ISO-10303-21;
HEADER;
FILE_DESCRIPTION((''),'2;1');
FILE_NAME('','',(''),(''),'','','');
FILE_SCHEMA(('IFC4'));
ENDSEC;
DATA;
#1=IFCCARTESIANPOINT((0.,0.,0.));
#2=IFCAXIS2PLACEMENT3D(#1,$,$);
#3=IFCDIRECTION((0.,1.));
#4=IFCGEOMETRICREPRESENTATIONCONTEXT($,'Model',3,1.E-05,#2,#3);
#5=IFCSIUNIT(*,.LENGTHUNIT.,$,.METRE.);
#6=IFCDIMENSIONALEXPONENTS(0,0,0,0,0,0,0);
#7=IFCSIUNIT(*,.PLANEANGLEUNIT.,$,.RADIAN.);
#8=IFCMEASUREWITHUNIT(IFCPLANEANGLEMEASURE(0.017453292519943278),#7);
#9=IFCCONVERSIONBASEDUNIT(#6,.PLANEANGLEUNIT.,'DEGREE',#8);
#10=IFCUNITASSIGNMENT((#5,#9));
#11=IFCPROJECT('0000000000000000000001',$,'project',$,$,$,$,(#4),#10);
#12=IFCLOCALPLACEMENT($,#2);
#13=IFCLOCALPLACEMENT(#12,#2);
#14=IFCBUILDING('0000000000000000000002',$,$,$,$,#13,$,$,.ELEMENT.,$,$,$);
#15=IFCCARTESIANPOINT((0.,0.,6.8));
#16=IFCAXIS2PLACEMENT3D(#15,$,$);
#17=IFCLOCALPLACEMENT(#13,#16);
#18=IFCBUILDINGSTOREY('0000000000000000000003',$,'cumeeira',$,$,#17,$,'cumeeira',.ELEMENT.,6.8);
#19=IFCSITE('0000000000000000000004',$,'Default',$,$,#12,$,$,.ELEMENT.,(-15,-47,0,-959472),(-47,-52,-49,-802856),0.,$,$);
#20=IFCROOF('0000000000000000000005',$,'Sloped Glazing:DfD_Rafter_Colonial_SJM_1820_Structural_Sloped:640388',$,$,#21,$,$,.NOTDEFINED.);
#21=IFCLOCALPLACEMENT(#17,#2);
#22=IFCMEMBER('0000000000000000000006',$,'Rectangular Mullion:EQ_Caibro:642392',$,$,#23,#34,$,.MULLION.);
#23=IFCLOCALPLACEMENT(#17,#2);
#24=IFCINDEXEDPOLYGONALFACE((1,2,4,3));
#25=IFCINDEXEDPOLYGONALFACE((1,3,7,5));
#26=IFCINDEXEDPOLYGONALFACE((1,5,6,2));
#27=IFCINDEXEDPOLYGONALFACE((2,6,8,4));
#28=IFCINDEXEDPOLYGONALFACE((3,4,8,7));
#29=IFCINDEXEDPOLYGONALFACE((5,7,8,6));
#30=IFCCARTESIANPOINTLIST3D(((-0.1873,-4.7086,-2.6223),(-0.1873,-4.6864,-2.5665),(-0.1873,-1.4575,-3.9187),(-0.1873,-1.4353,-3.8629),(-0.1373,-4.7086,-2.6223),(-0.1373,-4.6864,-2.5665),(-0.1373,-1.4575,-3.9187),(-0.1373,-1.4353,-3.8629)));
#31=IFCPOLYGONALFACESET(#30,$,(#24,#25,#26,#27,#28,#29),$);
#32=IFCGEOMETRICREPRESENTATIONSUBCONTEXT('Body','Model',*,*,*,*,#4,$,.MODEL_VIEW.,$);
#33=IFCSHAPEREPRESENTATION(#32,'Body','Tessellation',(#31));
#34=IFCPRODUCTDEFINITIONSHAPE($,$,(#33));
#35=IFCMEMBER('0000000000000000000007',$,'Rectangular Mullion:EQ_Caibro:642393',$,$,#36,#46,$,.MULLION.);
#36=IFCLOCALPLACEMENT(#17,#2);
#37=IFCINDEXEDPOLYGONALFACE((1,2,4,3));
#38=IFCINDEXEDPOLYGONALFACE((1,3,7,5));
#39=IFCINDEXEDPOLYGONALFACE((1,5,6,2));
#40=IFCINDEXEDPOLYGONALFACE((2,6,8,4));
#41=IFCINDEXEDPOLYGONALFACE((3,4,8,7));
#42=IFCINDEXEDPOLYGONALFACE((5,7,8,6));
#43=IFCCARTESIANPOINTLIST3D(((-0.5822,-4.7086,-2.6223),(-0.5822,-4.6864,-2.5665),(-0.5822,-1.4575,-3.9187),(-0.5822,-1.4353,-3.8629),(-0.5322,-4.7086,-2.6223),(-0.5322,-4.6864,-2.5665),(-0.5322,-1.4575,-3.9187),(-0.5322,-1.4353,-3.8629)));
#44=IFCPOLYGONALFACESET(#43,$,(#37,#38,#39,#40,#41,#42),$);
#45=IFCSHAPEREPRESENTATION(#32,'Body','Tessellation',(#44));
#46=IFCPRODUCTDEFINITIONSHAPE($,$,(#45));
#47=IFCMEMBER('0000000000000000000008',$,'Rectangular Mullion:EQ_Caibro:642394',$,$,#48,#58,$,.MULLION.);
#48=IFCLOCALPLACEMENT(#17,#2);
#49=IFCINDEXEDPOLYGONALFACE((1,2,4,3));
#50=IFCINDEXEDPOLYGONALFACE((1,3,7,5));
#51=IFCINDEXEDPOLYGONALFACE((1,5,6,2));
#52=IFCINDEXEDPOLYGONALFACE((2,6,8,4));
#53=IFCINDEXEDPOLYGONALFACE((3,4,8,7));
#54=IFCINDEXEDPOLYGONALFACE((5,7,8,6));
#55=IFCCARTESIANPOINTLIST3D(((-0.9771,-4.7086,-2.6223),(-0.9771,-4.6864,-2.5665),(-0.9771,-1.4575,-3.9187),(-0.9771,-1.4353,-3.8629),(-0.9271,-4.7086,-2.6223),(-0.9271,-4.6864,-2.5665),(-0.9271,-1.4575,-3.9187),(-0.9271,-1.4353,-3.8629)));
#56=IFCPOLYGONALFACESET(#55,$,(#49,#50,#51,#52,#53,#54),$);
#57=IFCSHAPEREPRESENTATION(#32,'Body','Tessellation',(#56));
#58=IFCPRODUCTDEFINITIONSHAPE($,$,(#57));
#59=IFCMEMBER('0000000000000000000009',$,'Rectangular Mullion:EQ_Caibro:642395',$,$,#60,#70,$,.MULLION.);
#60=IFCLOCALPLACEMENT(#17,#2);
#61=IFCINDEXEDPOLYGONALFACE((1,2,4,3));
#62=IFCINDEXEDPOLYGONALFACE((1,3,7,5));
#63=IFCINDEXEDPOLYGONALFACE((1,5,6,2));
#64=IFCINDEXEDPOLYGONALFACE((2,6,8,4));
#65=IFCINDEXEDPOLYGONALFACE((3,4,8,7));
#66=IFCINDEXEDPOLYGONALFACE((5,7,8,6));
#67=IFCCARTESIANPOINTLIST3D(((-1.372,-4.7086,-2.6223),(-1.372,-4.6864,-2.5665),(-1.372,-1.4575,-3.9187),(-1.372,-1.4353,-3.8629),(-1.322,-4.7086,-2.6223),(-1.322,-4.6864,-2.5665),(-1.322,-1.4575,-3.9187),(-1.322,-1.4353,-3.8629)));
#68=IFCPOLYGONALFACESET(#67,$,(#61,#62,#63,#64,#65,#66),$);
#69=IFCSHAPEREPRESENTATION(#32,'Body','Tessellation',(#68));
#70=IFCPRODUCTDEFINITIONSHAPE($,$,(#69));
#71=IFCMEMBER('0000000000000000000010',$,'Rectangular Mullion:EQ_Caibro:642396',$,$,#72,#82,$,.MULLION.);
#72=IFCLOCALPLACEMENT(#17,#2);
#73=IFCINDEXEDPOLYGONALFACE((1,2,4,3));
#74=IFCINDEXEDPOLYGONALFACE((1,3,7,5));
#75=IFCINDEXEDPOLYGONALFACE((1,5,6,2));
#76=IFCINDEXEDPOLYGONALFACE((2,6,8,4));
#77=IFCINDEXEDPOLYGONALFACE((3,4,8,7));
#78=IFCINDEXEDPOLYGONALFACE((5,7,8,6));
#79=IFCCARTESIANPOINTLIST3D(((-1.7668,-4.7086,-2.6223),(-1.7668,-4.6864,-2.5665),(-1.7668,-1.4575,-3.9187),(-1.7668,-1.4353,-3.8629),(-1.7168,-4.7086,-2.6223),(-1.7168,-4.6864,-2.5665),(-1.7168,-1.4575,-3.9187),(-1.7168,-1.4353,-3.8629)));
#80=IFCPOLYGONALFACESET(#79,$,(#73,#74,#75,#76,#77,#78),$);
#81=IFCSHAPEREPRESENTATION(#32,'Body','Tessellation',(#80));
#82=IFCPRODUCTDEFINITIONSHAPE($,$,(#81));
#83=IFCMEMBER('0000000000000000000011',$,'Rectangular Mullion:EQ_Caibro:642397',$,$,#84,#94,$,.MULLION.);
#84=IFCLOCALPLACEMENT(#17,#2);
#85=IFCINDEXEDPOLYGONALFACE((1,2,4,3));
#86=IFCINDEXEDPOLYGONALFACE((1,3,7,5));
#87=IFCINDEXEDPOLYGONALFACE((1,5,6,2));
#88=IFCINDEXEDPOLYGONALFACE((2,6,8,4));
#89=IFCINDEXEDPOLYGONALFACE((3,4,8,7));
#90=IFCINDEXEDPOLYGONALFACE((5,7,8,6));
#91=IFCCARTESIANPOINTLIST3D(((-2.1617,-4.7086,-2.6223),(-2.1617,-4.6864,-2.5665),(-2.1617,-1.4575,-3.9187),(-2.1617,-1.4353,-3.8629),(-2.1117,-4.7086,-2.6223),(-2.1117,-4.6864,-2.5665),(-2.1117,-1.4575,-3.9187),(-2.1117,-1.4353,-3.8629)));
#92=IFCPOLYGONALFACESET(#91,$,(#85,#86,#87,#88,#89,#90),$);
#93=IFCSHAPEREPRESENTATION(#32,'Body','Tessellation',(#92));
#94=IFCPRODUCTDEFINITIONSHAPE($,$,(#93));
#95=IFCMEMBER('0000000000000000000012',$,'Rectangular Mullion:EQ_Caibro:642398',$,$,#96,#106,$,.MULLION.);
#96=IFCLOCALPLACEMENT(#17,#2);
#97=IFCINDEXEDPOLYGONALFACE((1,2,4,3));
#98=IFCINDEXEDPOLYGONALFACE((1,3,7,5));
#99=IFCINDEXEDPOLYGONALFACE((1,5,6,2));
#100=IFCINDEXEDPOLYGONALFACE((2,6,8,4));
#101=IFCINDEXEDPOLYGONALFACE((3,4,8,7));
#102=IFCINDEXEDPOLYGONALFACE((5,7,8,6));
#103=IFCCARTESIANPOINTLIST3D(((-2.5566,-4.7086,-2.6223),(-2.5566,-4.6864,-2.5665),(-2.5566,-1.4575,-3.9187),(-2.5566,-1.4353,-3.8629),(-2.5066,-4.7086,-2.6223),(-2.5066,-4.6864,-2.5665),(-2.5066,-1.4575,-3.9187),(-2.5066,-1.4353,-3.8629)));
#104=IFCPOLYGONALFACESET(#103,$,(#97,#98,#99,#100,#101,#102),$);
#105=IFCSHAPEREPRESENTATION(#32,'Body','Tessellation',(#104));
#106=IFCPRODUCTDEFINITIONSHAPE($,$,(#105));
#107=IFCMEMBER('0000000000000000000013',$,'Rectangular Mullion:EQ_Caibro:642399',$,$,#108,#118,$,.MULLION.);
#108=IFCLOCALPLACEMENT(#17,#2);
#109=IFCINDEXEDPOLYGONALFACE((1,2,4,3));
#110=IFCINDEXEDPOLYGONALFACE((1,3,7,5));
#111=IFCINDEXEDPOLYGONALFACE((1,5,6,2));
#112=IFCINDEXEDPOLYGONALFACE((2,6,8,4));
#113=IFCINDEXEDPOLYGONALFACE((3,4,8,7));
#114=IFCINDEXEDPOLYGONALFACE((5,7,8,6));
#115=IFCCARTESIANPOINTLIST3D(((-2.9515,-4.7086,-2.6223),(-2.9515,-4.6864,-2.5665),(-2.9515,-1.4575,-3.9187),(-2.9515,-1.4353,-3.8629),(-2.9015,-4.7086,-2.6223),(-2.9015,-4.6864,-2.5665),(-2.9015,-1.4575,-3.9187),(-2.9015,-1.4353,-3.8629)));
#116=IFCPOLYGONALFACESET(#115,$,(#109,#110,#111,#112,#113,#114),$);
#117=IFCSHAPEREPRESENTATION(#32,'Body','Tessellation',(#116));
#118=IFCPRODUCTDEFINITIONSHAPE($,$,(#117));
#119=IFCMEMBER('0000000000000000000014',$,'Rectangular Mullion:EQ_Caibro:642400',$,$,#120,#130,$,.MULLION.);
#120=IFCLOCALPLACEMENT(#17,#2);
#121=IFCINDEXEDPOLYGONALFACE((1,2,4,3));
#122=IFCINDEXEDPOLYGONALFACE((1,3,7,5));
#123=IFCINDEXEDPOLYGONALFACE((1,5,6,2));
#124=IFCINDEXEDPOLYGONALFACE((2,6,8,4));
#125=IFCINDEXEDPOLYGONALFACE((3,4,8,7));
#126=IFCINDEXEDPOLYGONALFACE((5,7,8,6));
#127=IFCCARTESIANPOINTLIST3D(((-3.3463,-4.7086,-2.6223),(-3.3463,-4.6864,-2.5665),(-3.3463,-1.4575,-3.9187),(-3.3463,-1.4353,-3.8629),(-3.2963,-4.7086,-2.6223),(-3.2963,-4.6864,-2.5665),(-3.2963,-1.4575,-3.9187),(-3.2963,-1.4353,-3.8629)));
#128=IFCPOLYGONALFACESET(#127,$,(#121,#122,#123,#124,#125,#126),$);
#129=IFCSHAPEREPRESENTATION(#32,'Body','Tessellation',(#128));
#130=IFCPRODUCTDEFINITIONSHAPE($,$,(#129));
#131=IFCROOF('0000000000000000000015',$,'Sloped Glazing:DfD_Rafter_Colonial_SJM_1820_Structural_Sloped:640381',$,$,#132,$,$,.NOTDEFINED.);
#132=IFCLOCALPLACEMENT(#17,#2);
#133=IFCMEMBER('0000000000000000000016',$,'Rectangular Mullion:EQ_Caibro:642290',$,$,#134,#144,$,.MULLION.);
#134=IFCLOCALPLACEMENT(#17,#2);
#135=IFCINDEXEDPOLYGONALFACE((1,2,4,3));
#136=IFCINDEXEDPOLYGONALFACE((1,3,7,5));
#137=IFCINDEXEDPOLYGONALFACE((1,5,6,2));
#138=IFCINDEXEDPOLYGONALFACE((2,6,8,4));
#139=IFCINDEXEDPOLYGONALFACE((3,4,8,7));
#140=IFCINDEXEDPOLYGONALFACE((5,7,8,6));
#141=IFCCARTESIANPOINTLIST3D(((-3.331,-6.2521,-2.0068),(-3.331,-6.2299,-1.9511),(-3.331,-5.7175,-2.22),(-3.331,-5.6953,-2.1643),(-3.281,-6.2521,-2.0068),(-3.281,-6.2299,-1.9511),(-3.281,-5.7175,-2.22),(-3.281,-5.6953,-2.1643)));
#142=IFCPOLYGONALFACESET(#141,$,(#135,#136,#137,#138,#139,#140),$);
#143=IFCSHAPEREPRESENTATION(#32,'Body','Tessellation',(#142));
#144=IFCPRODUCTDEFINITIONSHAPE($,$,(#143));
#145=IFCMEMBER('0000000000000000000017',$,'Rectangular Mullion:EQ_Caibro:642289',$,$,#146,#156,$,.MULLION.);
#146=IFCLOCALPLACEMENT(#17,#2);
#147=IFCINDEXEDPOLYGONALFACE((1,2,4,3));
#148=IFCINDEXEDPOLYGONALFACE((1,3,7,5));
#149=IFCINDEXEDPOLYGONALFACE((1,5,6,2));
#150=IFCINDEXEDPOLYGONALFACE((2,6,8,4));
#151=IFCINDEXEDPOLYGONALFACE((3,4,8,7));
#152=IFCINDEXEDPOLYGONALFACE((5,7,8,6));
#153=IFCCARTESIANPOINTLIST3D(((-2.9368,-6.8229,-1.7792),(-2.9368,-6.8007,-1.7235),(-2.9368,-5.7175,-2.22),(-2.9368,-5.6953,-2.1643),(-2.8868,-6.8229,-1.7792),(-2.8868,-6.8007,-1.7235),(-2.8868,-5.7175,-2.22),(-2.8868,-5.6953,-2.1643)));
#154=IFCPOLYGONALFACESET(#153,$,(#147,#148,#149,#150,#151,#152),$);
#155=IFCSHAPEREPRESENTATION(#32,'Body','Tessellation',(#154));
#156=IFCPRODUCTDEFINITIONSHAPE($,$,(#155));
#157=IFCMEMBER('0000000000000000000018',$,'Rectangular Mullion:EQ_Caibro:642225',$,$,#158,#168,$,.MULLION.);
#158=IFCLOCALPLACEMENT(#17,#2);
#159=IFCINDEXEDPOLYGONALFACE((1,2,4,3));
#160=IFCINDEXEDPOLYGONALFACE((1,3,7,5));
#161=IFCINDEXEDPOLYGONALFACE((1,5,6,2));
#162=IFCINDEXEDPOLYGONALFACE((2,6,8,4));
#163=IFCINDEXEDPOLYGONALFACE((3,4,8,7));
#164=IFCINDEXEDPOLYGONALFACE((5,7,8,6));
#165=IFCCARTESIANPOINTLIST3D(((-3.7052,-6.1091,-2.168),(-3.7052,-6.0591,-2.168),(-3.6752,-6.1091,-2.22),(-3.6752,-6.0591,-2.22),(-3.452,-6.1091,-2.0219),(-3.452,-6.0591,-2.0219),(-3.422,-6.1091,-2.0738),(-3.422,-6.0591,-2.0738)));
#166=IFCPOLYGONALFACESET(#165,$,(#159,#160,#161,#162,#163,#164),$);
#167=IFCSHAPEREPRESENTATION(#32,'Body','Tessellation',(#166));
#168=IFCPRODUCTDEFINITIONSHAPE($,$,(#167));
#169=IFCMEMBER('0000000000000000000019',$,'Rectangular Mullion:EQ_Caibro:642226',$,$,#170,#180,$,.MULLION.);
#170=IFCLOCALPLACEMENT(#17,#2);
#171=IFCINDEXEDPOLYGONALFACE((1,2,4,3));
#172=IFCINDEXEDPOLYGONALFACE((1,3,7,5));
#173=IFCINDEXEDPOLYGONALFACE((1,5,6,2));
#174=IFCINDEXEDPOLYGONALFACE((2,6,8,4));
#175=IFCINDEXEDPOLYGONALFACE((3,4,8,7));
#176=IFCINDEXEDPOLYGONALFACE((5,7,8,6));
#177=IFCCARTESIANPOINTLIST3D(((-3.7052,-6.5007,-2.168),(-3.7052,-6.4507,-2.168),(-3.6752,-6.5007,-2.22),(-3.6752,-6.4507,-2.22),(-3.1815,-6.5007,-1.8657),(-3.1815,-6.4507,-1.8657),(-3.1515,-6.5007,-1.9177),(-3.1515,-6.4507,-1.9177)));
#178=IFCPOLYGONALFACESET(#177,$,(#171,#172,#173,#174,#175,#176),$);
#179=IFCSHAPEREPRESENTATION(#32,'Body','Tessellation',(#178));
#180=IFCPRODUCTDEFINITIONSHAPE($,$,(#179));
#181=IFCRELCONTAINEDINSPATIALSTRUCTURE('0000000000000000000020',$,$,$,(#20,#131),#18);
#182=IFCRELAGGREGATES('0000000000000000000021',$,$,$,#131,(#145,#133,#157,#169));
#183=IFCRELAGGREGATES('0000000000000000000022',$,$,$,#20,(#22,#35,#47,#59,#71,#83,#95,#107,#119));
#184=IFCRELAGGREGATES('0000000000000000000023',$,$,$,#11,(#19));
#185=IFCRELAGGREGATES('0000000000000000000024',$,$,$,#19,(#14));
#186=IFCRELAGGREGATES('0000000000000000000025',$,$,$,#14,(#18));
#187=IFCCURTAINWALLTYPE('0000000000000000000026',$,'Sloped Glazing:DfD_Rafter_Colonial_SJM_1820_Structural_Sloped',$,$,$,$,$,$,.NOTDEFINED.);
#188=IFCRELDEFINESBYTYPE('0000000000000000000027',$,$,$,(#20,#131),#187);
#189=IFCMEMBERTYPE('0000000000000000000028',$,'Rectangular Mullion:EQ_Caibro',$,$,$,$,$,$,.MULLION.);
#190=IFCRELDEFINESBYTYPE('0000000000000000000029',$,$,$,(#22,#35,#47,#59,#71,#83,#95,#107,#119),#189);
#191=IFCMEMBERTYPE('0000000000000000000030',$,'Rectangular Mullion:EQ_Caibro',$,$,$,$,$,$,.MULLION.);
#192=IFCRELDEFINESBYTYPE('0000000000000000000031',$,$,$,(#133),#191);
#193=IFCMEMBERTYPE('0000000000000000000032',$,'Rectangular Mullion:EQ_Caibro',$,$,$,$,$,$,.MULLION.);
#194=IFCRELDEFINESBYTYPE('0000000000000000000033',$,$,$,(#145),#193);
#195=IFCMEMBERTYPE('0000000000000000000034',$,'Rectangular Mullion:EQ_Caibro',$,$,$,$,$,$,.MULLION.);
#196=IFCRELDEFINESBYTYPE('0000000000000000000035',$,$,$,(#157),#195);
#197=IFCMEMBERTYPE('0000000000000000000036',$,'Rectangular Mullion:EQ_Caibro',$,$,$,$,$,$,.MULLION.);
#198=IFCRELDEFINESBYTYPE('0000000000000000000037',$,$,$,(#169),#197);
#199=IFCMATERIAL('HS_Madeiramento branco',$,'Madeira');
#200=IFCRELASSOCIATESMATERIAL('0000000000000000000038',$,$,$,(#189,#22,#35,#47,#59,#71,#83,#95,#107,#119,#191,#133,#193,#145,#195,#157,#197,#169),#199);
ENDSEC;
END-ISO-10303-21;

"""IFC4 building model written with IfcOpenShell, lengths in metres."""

from ifc_helpers import new_model, entity, si_unit, converted_unit, direction, frame, origin, place, context, subcontext, project, spatial, indexed_curve, outline, extrude, source, transform, mapped, material, type_object, type_shapes, element, aggregate, save


model = new_model("IFC4")

# Units and contexts
model_context = context("Model", 3, precision=1e-05, world=origin(), true_north=direction((0.0, 1.0)))
body_context = subcontext(model_context, "Body", "Model", "MODEL_VIEW")
ifc_project = project(units=[si_unit("LENGTHUNIT", "METRE"), converted_unit("PLANEANGLEUNIT", "DEGREE", entity("IfcPlaneAngleMeasure", 0.017453292519943278), si_unit("PLANEANGLEUNIT", "RADIAN"), dimensions=[0, 0, 0, 0, 0, 0, 0])], contexts=[model_context])

# Site, building, storey
site_placement = place(None, origin())
site = spatial("IfcSite", under=ifc_project, at=site_placement, Name="Default", CompositionType="ELEMENT", RefLatitude=(-15, -47, 0, -959472), RefLongitude=(-47, -52, -49, -802856), RefElevation=0.0)
building_placement = place(site_placement, origin())
building = spatial("IfcBuilding", under=site, at=building_placement, CompositionType="ELEMENT")
storey_placement = place(building_placement, frame((0.0, 0.0, 6.8)))
storey = spatial("IfcBuildingStorey", under=building, at=storey_placement, Name="cumeeira", LongName="cumeeira", CompositionType="ELEMENT", Elevation=6.8)

# Roofs, members
curtain_wall_type = type_object("IfcCurtainWallType", Name="Sloped Glazing:DfD_Rafter_Colonial_SJM_1820_Structural_Sloped", PredefinedType="NOTDEFINED")
roof_1_placement = place(storey_placement, frame((0.0, 0.0, -6.8)))
roof_1 = element("IfcRoof", 1, at=roof_1_placement, inside=storey, type_object=curtain_wall_type, Name="Sloped Glazing:DfD_Rafter_Colonial_SJM_1820_Structural_Sloped:640388", PredefinedType="NOTDEFINED")
ifc_material = material(Name="HS_Madeiramento branco", Category="Madeira")
member_type_1 = type_object("IfcMemberType", Name="Rectangular Mullion:EQ_Caibro", PredefinedType="MULLION", material=ifc_material)
shared_shape_1 = source(origin(), body_context, "Body", "SweptSolid", [
    extrude(outline(indexed_curve([(-0.025, -0.03), (0.025, -0.03), (0.025, 0.03), (-0.025, 0.03), (-0.025, -0.03)], self_intersect=False)), frame((0.0, -0.03, -3.5), z_axis=(0.0, 0.0, 1.0), x_axis=(-1.0, 0.0, 0.0)), (0.0, 0.0, 1.0), 3.5),
])
type_shapes(member_type_1, [shared_shape_1])
member_1_placement = place(roof_1_placement, frame((-0.1623, -4.7086, 4.1777), z_axis=(0.0, -0.928874, 0.370395), x_axis=(-1.0, 0.0, 0.0)))
member_1 = element("IfcMember", 2, at=member_1_placement, type_object=member_type_1, material=ifc_material, Name="Rectangular Mullion:EQ_Caibro:642392", PredefinedType="MULLION", context=body_context, shape_type="MappedRepresentation", body=[
    mapped(shared_shape_1, transform((0.0, 0.0, 0.0), scale=1.0)),
])
member_2_placement = place(roof_1_placement, frame((-0.5572, -4.7086, 4.1777), z_axis=(0.0, -0.928874, 0.370395), x_axis=(-1.0, 0.0, 0.0)))
member_2 = element("IfcMember", 3, at=member_2_placement, type_object=member_type_1, material=ifc_material, Name="Rectangular Mullion:EQ_Caibro:642393", PredefinedType="MULLION", context=body_context, shape_type="MappedRepresentation", body=[
    mapped(shared_shape_1, transform((0.0, 0.0, 0.0), scale=1.0)),
])
member_3_placement = place(roof_1_placement, frame((-0.9521, -4.7086, 4.1777), z_axis=(0.0, -0.928874, 0.370395), x_axis=(-1.0, 0.0, 0.0)))
member_3 = element("IfcMember", 4, at=member_3_placement, type_object=member_type_1, material=ifc_material, Name="Rectangular Mullion:EQ_Caibro:642394", PredefinedType="MULLION", context=body_context, shape_type="MappedRepresentation", body=[
    mapped(shared_shape_1, transform((0.0, 0.0, 0.0), scale=1.0)),
])
member_4_placement = place(roof_1_placement, frame((-1.347, -4.7086, 4.1777), z_axis=(0.0, -0.928874, 0.370395), x_axis=(-1.0, 0.0, 0.0)))
member_4 = element("IfcMember", 5, at=member_4_placement, type_object=member_type_1, material=ifc_material, Name="Rectangular Mullion:EQ_Caibro:642395", PredefinedType="MULLION", context=body_context, shape_type="MappedRepresentation", body=[
    mapped(shared_shape_1, transform((0.0, 0.0, 0.0), scale=1.0)),
])
member_5_placement = place(roof_1_placement, frame((-1.7418, -4.7086, 4.1777), z_axis=(0.0, -0.928874, 0.370395), x_axis=(-1.0, 0.0, 0.0)))
member_5 = element("IfcMember", 6, at=member_5_placement, type_object=member_type_1, material=ifc_material, Name="Rectangular Mullion:EQ_Caibro:642396", PredefinedType="MULLION", context=body_context, shape_type="MappedRepresentation", body=[
    mapped(shared_shape_1, transform((0.0, 0.0, 0.0), scale=1.0)),
])
member_6_placement = place(roof_1_placement, frame((-2.1367, -4.7086, 4.1777), z_axis=(0.0, -0.928874, 0.370395), x_axis=(-1.0, 0.0, 0.0)))
member_6 = element("IfcMember", 7, at=member_6_placement, type_object=member_type_1, material=ifc_material, Name="Rectangular Mullion:EQ_Caibro:642397", PredefinedType="MULLION", context=body_context, shape_type="MappedRepresentation", body=[
    mapped(shared_shape_1, transform((0.0, 0.0, 0.0), scale=1.0)),
])
member_7_placement = place(roof_1_placement, frame((-2.5316, -4.7086, 4.1777), z_axis=(0.0, -0.928874, 0.370395), x_axis=(-1.0, 0.0, 0.0)))
member_7 = element("IfcMember", 8, at=member_7_placement, type_object=member_type_1, material=ifc_material, Name="Rectangular Mullion:EQ_Caibro:642398", PredefinedType="MULLION", context=body_context, shape_type="MappedRepresentation", body=[
    mapped(shared_shape_1, transform((0.0, 0.0, 0.0), scale=1.0)),
])
member_8_placement = place(roof_1_placement, frame((-2.9265, -4.7086, 4.1777), z_axis=(0.0, -0.928874, 0.370395), x_axis=(-1.0, 0.0, 0.0)))
member_8 = element("IfcMember", 9, at=member_8_placement, type_object=member_type_1, material=ifc_material, Name="Rectangular Mullion:EQ_Caibro:642399", PredefinedType="MULLION", context=body_context, shape_type="MappedRepresentation", body=[
    mapped(shared_shape_1, transform((0.0, 0.0, 0.0), scale=1.0)),
])
member_9_placement = place(roof_1_placement, frame((-3.3213, -4.7086, 4.1777), z_axis=(0.0, -0.928874, 0.370395), x_axis=(-1.0, 0.0, 0.0)))
member_9 = element("IfcMember", 10, at=member_9_placement, type_object=member_type_1, material=ifc_material, Name="Rectangular Mullion:EQ_Caibro:642400", PredefinedType="MULLION", context=body_context, shape_type="MappedRepresentation", body=[
    mapped(shared_shape_1, transform((0.0, 0.0, 0.0), scale=1.0)),
])
roof_2_placement = place(storey_placement, frame((0.0, 0.0, -6.8)))
roof_2 = element("IfcRoof", 11, at=roof_2_placement, inside=storey, type_object=curtain_wall_type, Name="Sloped Glazing:DfD_Rafter_Colonial_SJM_1820_Structural_Sloped:640381", PredefinedType="NOTDEFINED")
member_type_2 = type_object("IfcMemberType", Name="Rectangular Mullion:EQ_Caibro", PredefinedType="MULLION", material=ifc_material)
shared_shape_2 = source(origin(), body_context, "Body", "SweptSolid", [
    extrude(outline(indexed_curve([(-0.025, -0.03), (0.025, -0.03), (0.025, 0.03), (-0.025, 0.03), (-0.025, -0.03)], self_intersect=False)), frame((0.0, -0.03, -0.5755), z_axis=(0.0, 0.0, 1.0), x_axis=(-1.0, 0.0, 0.0)), (0.0, 0.0, 1.0), 0.5755),
])
type_shapes(member_type_2, [shared_shape_2])
member_10_placement = place(roof_2_placement, frame((-3.306, -6.2521, 4.7932), z_axis=(0.0, -0.928878, 0.370385), x_axis=(-1.0, 0.0, 0.0)))
member_10 = element("IfcMember", 12, at=member_10_placement, type_object=member_type_2, material=ifc_material, Name="Rectangular Mullion:EQ_Caibro:642290", PredefinedType="MULLION", context=body_context, shape_type="MappedRepresentation", body=[
    mapped(shared_shape_2, transform((0.0, 0.0, 0.0), scale=1.0)),
])
member_type_3 = type_object("IfcMemberType", Name="Rectangular Mullion:EQ_Caibro", PredefinedType="MULLION", material=ifc_material)
shared_shape_3 = source(origin(), body_context, "Body", "SweptSolid", [
    extrude(outline(indexed_curve([(-0.025, -0.03), (0.025, -0.03), (0.025, 0.03), (-0.025, 0.03), (-0.025, -0.03)], self_intersect=False)), frame((0.0, -0.03, -1.19), z_axis=(0.0, 0.0, 1.0), x_axis=(-1.0, 0.0, 0.0)), (0.0, 0.0, 1.0), 1.19),
])
type_shapes(member_type_3, [shared_shape_3])
member_11_placement = place(roof_2_placement, frame((-2.9118, -6.8229, 5.0208), z_axis=(0.0, -0.928878, 0.370385), x_axis=(-1.0, 0.0, 0.0)))
member_11 = element("IfcMember", 13, at=member_11_placement, type_object=member_type_3, material=ifc_material, Name="Rectangular Mullion:EQ_Caibro:642289", PredefinedType="MULLION", context=body_context, shape_type="MappedRepresentation", body=[
    mapped(shared_shape_3, transform((0.0, 0.0, 0.0), scale=1.0)),
])
member_type_4 = type_object("IfcMemberType", Name="Rectangular Mullion:EQ_Caibro", PredefinedType="MULLION", material=ifc_material)
shared_shape_4 = source(origin(), body_context, "Body", "SweptSolid", [
    extrude(outline(indexed_curve([(-0.025, -0.03), (0.025, -0.03), (0.025, 0.03), (-0.025, 0.03), (-0.025, -0.03)], self_intersect=False)), frame((0.0, -0.03, -0.2924), z_axis=(0.0, 0.0, 1.0), x_axis=(-1.0, 0.0, 0.0)), (0.0, 0.0, 1.0), 0.2924),
])
type_shapes(member_type_4, [shared_shape_4])
member_12_placement = place(roof_2_placement, frame((-3.422, -6.0841, 4.7262), z_axis=(0.866025, 0.0, 0.5), x_axis=(0.0, -1.0, 0.0)))
member_12 = element("IfcMember", 14, at=member_12_placement, type_object=member_type_4, material=ifc_material, Name="Rectangular Mullion:EQ_Caibro:642225", PredefinedType="MULLION", context=body_context, shape_type="MappedRepresentation", body=[
    mapped(shared_shape_4, transform((0.0, 0.0, 0.0), scale=1.0)),
])
member_type_5 = type_object("IfcMemberType", Name="Rectangular Mullion:EQ_Caibro", PredefinedType="MULLION", material=ifc_material)
shared_shape_5 = source(origin(), body_context, "Body", "SweptSolid", [
    extrude(outline(indexed_curve([(-0.025, -0.03), (0.025, -0.03), (0.025, 0.03), (-0.025, 0.03), (-0.025, -0.03)], self_intersect=False)), frame((0.0, -0.03, -0.6047), z_axis=(0.0, 0.0, 1.0), x_axis=(-1.0, 0.0, 0.0)), (0.0, 0.0, 1.0), 0.6047),
])
type_shapes(member_type_5, [shared_shape_5])
member_13_placement = place(roof_2_placement, frame((-3.1515, -6.4757, 4.8823), z_axis=(0.866025, 0.0, 0.5), x_axis=(0.0, -1.0, 0.0)))
member_13 = element("IfcMember", 15, at=member_13_placement, type_object=member_type_5, material=ifc_material, Name="Rectangular Mullion:EQ_Caibro:642226", PredefinedType="MULLION", context=body_context, shape_type="MappedRepresentation", body=[
    mapped(shared_shape_5, transform((0.0, 0.0, 0.0), scale=1.0)),
])
aggregate(roof_2, [member_11, member_10, member_12, member_13])

aggregate(roof_1, [member_1, member_2, member_3, member_4, member_5, member_6, member_7, member_8, member_9])

save(model, "model.ifc")
